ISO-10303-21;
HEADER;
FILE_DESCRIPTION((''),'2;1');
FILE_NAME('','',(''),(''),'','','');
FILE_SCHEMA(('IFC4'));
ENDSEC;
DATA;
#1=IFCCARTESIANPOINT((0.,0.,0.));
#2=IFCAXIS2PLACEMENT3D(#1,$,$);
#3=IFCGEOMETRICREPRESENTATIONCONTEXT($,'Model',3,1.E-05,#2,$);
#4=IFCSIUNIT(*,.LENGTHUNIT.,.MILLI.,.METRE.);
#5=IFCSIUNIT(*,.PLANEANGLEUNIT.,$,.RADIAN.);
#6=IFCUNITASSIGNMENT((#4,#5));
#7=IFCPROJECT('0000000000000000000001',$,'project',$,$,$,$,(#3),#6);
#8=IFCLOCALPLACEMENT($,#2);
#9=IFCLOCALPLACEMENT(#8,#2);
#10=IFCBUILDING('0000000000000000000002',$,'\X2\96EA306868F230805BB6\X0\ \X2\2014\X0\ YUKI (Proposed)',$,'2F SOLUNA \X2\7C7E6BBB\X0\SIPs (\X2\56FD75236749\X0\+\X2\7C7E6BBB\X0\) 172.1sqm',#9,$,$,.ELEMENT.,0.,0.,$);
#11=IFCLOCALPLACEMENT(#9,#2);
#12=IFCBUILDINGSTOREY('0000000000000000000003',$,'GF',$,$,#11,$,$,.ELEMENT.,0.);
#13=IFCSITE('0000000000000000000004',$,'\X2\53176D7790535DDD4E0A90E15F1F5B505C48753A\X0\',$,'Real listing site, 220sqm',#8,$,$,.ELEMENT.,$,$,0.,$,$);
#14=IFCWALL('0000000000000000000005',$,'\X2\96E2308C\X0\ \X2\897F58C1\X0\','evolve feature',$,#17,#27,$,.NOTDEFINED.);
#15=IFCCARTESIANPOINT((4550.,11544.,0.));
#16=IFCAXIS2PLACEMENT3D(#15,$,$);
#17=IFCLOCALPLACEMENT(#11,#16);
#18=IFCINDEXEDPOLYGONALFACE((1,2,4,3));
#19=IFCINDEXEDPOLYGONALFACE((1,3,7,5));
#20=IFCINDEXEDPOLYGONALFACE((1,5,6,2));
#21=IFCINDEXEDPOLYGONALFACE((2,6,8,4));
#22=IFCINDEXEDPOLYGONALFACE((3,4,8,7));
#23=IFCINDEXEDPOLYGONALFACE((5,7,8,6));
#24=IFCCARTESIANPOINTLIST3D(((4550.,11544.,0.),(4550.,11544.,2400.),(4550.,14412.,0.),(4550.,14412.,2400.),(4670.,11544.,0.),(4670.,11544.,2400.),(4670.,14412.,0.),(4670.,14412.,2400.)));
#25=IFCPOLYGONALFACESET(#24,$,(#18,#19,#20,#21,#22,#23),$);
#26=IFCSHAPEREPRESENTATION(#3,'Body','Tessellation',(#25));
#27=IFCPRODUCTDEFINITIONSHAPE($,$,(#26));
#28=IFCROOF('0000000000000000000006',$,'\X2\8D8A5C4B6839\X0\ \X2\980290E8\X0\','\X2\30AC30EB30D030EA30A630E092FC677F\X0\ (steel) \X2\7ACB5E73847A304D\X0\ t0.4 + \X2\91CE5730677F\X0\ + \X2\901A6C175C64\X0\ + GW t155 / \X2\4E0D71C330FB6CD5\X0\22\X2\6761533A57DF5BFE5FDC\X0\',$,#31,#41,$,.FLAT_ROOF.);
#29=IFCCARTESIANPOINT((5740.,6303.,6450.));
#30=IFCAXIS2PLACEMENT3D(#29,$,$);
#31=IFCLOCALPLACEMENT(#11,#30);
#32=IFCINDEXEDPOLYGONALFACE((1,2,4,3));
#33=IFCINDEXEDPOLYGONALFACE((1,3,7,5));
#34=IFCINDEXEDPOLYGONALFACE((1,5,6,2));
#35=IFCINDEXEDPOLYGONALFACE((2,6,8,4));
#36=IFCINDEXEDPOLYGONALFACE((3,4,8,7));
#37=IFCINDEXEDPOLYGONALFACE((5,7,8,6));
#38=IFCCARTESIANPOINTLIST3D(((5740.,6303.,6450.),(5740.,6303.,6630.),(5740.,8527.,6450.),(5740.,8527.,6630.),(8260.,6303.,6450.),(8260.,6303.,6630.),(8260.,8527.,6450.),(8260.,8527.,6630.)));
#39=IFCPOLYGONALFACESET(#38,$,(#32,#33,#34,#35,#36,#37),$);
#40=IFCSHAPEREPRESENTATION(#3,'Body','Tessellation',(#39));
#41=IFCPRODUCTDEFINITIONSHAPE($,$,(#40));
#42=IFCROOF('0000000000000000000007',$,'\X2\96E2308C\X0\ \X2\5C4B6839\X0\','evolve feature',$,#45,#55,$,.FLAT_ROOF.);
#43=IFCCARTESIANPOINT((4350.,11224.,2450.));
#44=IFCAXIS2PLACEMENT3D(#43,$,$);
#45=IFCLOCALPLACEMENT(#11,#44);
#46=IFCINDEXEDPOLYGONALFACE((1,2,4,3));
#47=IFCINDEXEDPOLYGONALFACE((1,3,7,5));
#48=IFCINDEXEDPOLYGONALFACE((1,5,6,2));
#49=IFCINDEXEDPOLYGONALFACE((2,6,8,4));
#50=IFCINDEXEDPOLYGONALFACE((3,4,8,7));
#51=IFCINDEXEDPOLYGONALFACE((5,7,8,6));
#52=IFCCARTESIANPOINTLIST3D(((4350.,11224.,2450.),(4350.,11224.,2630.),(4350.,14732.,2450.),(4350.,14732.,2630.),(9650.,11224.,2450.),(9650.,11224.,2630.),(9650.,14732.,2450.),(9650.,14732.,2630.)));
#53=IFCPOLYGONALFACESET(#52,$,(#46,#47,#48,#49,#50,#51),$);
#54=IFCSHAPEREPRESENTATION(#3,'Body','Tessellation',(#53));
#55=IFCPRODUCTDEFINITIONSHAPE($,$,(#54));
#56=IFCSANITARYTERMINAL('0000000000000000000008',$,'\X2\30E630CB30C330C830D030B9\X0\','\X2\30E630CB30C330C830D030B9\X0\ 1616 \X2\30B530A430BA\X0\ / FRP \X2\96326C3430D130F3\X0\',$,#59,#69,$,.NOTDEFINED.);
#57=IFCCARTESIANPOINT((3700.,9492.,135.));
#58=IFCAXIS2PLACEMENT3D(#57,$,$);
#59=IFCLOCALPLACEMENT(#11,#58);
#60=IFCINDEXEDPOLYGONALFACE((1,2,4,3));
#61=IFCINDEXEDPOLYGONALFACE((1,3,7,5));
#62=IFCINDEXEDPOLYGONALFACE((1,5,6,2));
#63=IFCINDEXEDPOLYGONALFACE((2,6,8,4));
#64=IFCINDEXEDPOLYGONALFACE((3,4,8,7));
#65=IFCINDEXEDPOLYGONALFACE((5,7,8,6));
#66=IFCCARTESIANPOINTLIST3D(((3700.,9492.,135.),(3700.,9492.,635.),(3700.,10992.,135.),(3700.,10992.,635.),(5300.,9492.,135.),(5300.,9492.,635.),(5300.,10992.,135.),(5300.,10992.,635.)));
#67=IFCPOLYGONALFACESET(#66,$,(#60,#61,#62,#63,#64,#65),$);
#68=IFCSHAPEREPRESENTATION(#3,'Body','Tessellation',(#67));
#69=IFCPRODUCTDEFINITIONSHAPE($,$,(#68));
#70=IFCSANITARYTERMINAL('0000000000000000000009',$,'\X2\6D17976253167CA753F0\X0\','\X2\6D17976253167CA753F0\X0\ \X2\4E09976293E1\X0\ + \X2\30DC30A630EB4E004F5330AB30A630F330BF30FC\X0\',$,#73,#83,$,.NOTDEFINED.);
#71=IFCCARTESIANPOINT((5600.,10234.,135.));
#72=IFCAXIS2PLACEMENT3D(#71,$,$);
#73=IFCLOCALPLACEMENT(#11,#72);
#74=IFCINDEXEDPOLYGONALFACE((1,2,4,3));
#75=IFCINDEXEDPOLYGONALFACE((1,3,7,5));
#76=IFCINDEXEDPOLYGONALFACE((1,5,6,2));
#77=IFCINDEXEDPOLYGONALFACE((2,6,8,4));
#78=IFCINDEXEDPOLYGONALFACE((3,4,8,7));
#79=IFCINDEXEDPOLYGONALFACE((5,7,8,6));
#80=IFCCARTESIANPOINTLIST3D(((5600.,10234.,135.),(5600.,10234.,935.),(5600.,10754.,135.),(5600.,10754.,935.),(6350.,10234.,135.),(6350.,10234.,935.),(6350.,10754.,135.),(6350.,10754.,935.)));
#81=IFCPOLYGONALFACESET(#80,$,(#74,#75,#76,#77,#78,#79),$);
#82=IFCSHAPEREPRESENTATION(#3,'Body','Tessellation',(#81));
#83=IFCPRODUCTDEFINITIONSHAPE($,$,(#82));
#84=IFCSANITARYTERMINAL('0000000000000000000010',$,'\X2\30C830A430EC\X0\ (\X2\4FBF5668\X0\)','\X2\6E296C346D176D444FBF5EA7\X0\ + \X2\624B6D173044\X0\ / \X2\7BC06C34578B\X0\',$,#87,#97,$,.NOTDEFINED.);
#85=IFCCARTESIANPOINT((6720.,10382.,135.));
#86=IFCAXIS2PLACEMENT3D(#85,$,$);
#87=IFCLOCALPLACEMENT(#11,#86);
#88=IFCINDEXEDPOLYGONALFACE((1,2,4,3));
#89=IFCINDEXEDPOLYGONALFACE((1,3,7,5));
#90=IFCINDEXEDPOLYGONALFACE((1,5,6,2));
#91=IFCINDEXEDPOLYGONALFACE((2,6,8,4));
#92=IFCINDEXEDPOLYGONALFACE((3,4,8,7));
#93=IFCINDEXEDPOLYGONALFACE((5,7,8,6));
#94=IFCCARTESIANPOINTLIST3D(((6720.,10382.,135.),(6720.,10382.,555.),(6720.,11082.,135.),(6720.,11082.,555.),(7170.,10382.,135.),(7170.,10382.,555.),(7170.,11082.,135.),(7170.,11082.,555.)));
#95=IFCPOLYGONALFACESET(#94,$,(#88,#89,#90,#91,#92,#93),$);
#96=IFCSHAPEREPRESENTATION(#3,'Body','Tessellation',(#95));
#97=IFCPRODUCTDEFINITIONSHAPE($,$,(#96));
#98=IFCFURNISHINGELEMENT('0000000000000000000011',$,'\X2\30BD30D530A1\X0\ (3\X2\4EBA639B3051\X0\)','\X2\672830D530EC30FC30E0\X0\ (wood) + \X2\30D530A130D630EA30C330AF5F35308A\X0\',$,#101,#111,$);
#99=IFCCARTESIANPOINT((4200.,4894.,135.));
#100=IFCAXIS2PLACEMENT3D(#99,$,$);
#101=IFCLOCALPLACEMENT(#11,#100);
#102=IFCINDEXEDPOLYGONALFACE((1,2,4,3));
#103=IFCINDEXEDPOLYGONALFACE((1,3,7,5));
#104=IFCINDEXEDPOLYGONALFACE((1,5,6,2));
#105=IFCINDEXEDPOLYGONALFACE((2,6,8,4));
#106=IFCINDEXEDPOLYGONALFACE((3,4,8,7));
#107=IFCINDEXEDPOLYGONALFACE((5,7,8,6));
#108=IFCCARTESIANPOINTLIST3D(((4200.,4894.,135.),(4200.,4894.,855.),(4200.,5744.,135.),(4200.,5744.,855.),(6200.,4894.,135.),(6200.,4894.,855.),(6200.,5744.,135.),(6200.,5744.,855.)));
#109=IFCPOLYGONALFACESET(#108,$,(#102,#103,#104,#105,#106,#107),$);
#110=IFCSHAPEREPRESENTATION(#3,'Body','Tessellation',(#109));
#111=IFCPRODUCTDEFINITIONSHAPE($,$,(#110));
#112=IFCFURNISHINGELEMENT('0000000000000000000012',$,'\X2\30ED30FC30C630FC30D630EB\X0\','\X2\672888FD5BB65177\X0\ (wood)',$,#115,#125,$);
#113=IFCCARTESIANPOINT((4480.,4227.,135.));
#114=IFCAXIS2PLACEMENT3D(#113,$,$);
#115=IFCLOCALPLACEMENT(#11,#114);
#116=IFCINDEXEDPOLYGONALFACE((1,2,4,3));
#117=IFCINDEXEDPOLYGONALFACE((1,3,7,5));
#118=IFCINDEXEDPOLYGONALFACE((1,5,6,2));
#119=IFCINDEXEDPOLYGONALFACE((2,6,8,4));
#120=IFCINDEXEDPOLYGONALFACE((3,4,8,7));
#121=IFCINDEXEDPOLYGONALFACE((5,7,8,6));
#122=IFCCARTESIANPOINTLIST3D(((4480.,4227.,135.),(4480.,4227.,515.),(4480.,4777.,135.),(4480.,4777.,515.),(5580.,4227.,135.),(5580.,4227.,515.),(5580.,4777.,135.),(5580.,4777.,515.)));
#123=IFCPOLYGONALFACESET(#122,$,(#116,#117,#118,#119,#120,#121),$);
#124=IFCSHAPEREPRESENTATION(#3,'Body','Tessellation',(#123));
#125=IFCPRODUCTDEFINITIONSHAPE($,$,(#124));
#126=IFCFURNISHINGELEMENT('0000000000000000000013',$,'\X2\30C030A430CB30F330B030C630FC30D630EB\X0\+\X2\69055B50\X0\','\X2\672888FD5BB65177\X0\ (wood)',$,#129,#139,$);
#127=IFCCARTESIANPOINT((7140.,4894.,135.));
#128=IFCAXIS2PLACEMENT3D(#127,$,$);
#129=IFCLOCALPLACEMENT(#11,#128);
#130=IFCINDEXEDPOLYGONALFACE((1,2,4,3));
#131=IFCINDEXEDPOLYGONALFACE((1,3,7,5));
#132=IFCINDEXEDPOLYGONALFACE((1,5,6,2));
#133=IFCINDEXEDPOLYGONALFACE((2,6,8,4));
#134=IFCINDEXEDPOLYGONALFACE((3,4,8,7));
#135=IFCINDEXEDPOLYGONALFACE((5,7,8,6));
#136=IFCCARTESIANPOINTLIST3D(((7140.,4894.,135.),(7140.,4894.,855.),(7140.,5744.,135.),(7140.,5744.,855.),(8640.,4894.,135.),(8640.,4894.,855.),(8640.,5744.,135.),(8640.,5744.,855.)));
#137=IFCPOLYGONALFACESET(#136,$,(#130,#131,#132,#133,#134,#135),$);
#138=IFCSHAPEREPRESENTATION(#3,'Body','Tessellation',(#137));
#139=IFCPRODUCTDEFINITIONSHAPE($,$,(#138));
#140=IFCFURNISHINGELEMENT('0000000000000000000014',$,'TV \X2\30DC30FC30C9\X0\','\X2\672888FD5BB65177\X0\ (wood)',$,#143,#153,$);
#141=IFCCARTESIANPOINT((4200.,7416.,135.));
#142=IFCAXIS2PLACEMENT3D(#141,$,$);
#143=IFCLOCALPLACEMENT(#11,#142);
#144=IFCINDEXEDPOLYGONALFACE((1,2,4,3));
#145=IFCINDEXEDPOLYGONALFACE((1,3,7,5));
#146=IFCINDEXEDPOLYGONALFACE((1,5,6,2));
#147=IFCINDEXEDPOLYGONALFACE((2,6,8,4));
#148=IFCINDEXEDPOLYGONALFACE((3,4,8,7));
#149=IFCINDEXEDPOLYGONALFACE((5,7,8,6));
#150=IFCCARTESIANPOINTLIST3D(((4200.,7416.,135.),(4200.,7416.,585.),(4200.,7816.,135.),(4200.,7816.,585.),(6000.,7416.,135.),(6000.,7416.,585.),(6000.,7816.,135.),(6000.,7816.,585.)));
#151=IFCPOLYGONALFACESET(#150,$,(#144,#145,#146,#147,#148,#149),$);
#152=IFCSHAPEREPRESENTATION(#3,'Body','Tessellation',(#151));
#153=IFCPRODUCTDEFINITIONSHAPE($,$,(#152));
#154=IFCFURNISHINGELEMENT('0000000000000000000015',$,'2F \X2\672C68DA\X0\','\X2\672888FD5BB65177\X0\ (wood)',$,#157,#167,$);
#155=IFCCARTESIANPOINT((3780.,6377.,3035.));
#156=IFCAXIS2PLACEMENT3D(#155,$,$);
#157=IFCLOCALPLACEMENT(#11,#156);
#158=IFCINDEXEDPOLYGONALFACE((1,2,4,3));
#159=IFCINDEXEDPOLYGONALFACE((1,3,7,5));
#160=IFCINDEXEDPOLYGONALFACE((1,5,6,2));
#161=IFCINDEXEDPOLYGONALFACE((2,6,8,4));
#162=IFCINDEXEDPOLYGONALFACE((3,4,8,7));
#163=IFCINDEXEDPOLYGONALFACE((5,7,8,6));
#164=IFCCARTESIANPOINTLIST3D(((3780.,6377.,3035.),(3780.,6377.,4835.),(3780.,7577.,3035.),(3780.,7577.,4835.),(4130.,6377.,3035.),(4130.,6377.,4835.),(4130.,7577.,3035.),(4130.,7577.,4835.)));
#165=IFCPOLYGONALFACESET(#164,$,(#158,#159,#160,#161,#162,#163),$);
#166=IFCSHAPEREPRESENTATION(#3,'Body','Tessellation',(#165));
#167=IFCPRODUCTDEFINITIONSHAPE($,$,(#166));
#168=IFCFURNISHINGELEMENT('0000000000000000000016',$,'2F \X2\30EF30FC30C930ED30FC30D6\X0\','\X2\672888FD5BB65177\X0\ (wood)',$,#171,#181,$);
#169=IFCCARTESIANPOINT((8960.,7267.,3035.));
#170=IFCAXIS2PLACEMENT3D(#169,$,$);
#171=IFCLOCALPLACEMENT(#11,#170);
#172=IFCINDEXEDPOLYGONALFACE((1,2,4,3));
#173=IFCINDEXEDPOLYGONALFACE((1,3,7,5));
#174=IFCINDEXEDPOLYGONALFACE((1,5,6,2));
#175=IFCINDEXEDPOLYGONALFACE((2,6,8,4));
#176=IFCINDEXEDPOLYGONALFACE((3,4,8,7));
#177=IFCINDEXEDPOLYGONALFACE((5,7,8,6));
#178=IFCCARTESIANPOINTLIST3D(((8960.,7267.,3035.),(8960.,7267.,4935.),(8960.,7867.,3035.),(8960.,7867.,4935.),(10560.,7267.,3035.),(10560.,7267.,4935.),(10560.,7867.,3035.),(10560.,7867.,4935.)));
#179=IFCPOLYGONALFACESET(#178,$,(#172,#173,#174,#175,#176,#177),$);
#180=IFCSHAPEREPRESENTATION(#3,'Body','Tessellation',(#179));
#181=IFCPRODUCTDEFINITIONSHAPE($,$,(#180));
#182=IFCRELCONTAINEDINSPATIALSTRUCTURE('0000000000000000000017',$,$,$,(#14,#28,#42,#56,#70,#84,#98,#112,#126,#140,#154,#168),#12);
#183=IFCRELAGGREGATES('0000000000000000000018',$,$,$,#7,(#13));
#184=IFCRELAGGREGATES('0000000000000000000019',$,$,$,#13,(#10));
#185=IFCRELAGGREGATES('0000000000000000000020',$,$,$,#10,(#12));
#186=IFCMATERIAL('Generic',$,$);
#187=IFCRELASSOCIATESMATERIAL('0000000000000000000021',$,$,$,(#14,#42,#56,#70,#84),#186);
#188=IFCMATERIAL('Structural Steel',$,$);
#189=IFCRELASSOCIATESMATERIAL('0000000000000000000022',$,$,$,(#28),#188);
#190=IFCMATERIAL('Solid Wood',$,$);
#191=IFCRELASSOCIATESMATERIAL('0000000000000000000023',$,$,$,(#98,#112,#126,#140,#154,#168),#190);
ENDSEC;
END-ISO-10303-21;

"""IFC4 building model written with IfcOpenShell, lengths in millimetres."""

from ifc_helpers import new_model, si_unit, frame, frame_2d, origin, place, context, project, spatial, rectangle, extrude, material, element, save


model = new_model("IFC4")

# Units and contexts
model_context = context("Model", 3, precision=1e-05, world=origin())
ifc_project = project(units=[si_unit("LENGTHUNIT", "METRE", prefix="MILLI"), si_unit("PLANEANGLEUNIT", "RADIAN")], contexts=[model_context])

# Site, building, storey
site_placement = place(None, origin())
site = spatial("IfcSite", under=ifc_project, at=site_placement, Name="北海道川上郡弟子屈町", ObjectType="Real listing site, 220sqm", CompositionType="ELEMENT", RefElevation=0.0)
building_placement = place(site_placement, origin())
building = spatial("IfcBuilding", under=site, at=building_placement, Name="雪と棲む家 — YUKI (Proposed)", ObjectType="2F SOLUNA 籾殻SIPs (国産杉+籾殻) 172.1sqm", CompositionType="ELEMENT", ElevationOfRefHeight=0.0, ElevationOfTerrain=0.0)
storey_placement = place(building_placement, origin())
storey = spatial("IfcBuildingStorey", under=building, at=storey_placement, Name="GF", CompositionType="ELEMENT", Elevation=0.0)

# Shared definitions
ifc_material_1 = material(Name="Generic")

# Shared definitions
ifc_material_2 = material(Name="Solid Wood")

# Wall
wall_1_placement = place(storey_placement, frame((4550.0, 11544.0, 0.0)))
element("IfcWall", 1, at=wall_1_placement, inside=storey, material=ifc_material_1, Name="離れ 西壁", Description="evolve feature", PredefinedType="NOTDEFINED", context=model_context, shape_type="SweptSolid", body=[
    extrude(rectangle(XDim=120.0, YDim=2868.0, at=frame_2d((60.0, 1434.0))), frame((4550.0, 11544.0, 0.0)), (0.0, 0.0, 1.0), 2400.0),
])

# Roofs
ifc_material_3 = material(Name="Structural Steel")
roof_1_placement = place(storey_placement, frame((5740.0, 6303.0, 6450.0)))
element("IfcRoof", 2, at=roof_1_placement, inside=storey, material=ifc_material_3, Name="越屋根 頂部", Description="ガルバリウム鋼板 (steel) 立平葺き t0.4 + 野地板 + 通気層 + GW t155 / 不燃・法22条区域対応", PredefinedType="FLAT_ROOF", context=model_context, shape_type="SweptSolid", body=[
    extrude(rectangle(XDim=2520.0, YDim=2224.0, at=frame_2d((1260.0, 1112.0))), frame((5740.0, 6303.0, 6450.0)), (0.0, 0.0, 1.0), 180.0),
])
roof_2_placement = place(storey_placement, frame((4350.0, 11224.0, 2450.0)))
element("IfcRoof", 3, at=roof_2_placement, inside=storey, material=ifc_material_1, Name="離れ 屋根", Description="evolve feature", PredefinedType="FLAT_ROOF", context=model_context, shape_type="SweptSolid", body=[
    extrude(rectangle(XDim=5300.0, YDim=3508.0, at=frame_2d((2650.0, 1754.0))), frame((4350.0, 11224.0, 2450.0)), (0.0, 0.0, 1.0), 180.0),
])

# Sanitary terminals
sanitary_terminal_1_placement = place(storey_placement, frame((3700.0, 9492.0, 135.0)))
element("IfcSanitaryTerminal", 4, at=sanitary_terminal_1_placement, inside=storey, material=ifc_material_1, Name="ユニットバス", Description="ユニットバス 1616 サイズ / FRP 防水パン", PredefinedType="NOTDEFINED", context=model_context, shape_type="SweptSolid", body=[
    extrude(rectangle(XDim=1600.0, YDim=1500.0, at=frame_2d((800.0, 750.0))), frame((3700.0, 9492.0, 135.0)), (0.0, 0.0, 1.0), 500.0),
])
sanitary_terminal_2_placement = place(storey_placement, frame((5600.0, 10234.0, 135.0)))
element("IfcSanitaryTerminal", 5, at=sanitary_terminal_2_placement, inside=storey, material=ifc_material_1, Name="洗面化粧台", Description="洗面化粧台 三面鏡 + ボウル一体カウンター", PredefinedType="NOTDEFINED", context=model_context, shape_type="SweptSolid", body=[
    extrude(rectangle(XDim=750.0, YDim=520.0, at=frame_2d((375.0, 260.0))), frame((5600.0, 10234.0, 135.0)), (0.0, 0.0, 1.0), 800.0),
])
sanitary_terminal_3_placement = place(storey_placement, frame((6720.0, 10382.0, 135.0)))
element("IfcSanitaryTerminal", 6, at=sanitary_terminal_3_placement, inside=storey, material=ifc_material_1, Name="トイレ (便器)", Description="温水洗浄便座 + 手洗い / 節水型", PredefinedType="NOTDEFINED", context=model_context, shape_type="SweptSolid", body=[
    extrude(rectangle(XDim=450.0, YDim=700.0, at=frame_2d((225.0, 350.0))), frame((6720.0, 10382.0, 135.0)), (0.0, 0.0, 1.0), 420.0),
])

# Furnishing elements
furnishing_1_placement = place(storey_placement, frame((4200.0, 4894.0, 135.0)))
element("IfcFurnishingElement", 7, at=furnishing_1_placement, inside=storey, material=ifc_material_2, Name="ソファ (3人掛け)", Description="木フレーム (wood) + ファブリック張り", context=model_context, shape_type="SweptSolid", body=[
    extrude(rectangle(XDim=2000.0, YDim=850.0, at=frame_2d((1000.0, 425.0))), frame((4200.0, 4894.0, 135.0)), (0.0, 0.0, 1.0), 720.0),
])
furnishing_2_placement = place(storey_placement, frame((4480.0, 4227.0, 135.0)))
element("IfcFurnishingElement", 8, at=furnishing_2_placement, inside=storey, material=ifc_material_2, Name="ローテーブル", Description="木製家具 (wood)", context=model_context, shape_type="SweptSolid", body=[
    extrude(rectangle(XDim=1100.0, YDim=550.0, at=frame_2d((550.0, 275.0))), frame((4480.0, 4227.0, 135.0)), (0.0, 0.0, 1.0), 380.0),
])
furnishing_3_placement = place(storey_placement, frame((7140.0, 4894.0, 135.0)))
element("IfcFurnishingElement", 9, at=furnishing_3_placement, inside=storey, material=ifc_material_2, Name="ダイニングテーブル+椅子", Description="木製家具 (wood)", context=model_context, shape_type="SweptSolid", body=[
    extrude(rectangle(XDim=1500.0, YDim=850.0, at=frame_2d((750.0, 425.0))), frame((7140.0, 4894.0, 135.0)), (0.0, 0.0, 1.0), 720.0),
])
furnishing_4_placement = place(storey_placement, frame((4200.0, 7416.0, 135.0)))
element("IfcFurnishingElement", 10, at=furnishing_4_placement, inside=storey, material=ifc_material_2, Name="TV ボード", Description="木製家具 (wood)", context=model_context, shape_type="SweptSolid", body=[
    extrude(rectangle(XDim=1800.0, YDim=400.0, at=frame_2d((900.0, 200.0))), frame((4200.0, 7416.0, 135.0)), (0.0, 0.0, 1.0), 450.0),
])
furnishing_5_placement = place(storey_placement, frame((3780.0, 6377.0, 3035.0)))
element("IfcFurnishingElement", 11, at=furnishing_5_placement, inside=storey, material=ifc_material_2, Name="2F 本棚", Description="木製家具 (wood)", context=model_context, shape_type="SweptSolid", body=[
    extrude(rectangle(XDim=350.0, YDim=1200.0, at=frame_2d((175.0, 600.0))), frame((3780.0, 6377.0, 3035.0)), (0.0, 0.0, 1.0), 1800.0),
])
furnishing_6_placement = place(storey_placement, frame((8960.0, 7267.0, 3035.0)))
element("IfcFurnishingElement", 12, at=furnishing_6_placement, inside=storey, material=ifc_material_2, Name="2F ワードローブ", Description="木製家具 (wood)", context=model_context, shape_type="SweptSolid", body=[
    extrude(rectangle(XDim=1600.0, YDim=600.0, at=frame_2d((800.0, 300.0))), frame((8960.0, 7267.0, 3035.0)), (0.0, 0.0, 1.0), 1900.0),
])

save(model, "model.ifc")
